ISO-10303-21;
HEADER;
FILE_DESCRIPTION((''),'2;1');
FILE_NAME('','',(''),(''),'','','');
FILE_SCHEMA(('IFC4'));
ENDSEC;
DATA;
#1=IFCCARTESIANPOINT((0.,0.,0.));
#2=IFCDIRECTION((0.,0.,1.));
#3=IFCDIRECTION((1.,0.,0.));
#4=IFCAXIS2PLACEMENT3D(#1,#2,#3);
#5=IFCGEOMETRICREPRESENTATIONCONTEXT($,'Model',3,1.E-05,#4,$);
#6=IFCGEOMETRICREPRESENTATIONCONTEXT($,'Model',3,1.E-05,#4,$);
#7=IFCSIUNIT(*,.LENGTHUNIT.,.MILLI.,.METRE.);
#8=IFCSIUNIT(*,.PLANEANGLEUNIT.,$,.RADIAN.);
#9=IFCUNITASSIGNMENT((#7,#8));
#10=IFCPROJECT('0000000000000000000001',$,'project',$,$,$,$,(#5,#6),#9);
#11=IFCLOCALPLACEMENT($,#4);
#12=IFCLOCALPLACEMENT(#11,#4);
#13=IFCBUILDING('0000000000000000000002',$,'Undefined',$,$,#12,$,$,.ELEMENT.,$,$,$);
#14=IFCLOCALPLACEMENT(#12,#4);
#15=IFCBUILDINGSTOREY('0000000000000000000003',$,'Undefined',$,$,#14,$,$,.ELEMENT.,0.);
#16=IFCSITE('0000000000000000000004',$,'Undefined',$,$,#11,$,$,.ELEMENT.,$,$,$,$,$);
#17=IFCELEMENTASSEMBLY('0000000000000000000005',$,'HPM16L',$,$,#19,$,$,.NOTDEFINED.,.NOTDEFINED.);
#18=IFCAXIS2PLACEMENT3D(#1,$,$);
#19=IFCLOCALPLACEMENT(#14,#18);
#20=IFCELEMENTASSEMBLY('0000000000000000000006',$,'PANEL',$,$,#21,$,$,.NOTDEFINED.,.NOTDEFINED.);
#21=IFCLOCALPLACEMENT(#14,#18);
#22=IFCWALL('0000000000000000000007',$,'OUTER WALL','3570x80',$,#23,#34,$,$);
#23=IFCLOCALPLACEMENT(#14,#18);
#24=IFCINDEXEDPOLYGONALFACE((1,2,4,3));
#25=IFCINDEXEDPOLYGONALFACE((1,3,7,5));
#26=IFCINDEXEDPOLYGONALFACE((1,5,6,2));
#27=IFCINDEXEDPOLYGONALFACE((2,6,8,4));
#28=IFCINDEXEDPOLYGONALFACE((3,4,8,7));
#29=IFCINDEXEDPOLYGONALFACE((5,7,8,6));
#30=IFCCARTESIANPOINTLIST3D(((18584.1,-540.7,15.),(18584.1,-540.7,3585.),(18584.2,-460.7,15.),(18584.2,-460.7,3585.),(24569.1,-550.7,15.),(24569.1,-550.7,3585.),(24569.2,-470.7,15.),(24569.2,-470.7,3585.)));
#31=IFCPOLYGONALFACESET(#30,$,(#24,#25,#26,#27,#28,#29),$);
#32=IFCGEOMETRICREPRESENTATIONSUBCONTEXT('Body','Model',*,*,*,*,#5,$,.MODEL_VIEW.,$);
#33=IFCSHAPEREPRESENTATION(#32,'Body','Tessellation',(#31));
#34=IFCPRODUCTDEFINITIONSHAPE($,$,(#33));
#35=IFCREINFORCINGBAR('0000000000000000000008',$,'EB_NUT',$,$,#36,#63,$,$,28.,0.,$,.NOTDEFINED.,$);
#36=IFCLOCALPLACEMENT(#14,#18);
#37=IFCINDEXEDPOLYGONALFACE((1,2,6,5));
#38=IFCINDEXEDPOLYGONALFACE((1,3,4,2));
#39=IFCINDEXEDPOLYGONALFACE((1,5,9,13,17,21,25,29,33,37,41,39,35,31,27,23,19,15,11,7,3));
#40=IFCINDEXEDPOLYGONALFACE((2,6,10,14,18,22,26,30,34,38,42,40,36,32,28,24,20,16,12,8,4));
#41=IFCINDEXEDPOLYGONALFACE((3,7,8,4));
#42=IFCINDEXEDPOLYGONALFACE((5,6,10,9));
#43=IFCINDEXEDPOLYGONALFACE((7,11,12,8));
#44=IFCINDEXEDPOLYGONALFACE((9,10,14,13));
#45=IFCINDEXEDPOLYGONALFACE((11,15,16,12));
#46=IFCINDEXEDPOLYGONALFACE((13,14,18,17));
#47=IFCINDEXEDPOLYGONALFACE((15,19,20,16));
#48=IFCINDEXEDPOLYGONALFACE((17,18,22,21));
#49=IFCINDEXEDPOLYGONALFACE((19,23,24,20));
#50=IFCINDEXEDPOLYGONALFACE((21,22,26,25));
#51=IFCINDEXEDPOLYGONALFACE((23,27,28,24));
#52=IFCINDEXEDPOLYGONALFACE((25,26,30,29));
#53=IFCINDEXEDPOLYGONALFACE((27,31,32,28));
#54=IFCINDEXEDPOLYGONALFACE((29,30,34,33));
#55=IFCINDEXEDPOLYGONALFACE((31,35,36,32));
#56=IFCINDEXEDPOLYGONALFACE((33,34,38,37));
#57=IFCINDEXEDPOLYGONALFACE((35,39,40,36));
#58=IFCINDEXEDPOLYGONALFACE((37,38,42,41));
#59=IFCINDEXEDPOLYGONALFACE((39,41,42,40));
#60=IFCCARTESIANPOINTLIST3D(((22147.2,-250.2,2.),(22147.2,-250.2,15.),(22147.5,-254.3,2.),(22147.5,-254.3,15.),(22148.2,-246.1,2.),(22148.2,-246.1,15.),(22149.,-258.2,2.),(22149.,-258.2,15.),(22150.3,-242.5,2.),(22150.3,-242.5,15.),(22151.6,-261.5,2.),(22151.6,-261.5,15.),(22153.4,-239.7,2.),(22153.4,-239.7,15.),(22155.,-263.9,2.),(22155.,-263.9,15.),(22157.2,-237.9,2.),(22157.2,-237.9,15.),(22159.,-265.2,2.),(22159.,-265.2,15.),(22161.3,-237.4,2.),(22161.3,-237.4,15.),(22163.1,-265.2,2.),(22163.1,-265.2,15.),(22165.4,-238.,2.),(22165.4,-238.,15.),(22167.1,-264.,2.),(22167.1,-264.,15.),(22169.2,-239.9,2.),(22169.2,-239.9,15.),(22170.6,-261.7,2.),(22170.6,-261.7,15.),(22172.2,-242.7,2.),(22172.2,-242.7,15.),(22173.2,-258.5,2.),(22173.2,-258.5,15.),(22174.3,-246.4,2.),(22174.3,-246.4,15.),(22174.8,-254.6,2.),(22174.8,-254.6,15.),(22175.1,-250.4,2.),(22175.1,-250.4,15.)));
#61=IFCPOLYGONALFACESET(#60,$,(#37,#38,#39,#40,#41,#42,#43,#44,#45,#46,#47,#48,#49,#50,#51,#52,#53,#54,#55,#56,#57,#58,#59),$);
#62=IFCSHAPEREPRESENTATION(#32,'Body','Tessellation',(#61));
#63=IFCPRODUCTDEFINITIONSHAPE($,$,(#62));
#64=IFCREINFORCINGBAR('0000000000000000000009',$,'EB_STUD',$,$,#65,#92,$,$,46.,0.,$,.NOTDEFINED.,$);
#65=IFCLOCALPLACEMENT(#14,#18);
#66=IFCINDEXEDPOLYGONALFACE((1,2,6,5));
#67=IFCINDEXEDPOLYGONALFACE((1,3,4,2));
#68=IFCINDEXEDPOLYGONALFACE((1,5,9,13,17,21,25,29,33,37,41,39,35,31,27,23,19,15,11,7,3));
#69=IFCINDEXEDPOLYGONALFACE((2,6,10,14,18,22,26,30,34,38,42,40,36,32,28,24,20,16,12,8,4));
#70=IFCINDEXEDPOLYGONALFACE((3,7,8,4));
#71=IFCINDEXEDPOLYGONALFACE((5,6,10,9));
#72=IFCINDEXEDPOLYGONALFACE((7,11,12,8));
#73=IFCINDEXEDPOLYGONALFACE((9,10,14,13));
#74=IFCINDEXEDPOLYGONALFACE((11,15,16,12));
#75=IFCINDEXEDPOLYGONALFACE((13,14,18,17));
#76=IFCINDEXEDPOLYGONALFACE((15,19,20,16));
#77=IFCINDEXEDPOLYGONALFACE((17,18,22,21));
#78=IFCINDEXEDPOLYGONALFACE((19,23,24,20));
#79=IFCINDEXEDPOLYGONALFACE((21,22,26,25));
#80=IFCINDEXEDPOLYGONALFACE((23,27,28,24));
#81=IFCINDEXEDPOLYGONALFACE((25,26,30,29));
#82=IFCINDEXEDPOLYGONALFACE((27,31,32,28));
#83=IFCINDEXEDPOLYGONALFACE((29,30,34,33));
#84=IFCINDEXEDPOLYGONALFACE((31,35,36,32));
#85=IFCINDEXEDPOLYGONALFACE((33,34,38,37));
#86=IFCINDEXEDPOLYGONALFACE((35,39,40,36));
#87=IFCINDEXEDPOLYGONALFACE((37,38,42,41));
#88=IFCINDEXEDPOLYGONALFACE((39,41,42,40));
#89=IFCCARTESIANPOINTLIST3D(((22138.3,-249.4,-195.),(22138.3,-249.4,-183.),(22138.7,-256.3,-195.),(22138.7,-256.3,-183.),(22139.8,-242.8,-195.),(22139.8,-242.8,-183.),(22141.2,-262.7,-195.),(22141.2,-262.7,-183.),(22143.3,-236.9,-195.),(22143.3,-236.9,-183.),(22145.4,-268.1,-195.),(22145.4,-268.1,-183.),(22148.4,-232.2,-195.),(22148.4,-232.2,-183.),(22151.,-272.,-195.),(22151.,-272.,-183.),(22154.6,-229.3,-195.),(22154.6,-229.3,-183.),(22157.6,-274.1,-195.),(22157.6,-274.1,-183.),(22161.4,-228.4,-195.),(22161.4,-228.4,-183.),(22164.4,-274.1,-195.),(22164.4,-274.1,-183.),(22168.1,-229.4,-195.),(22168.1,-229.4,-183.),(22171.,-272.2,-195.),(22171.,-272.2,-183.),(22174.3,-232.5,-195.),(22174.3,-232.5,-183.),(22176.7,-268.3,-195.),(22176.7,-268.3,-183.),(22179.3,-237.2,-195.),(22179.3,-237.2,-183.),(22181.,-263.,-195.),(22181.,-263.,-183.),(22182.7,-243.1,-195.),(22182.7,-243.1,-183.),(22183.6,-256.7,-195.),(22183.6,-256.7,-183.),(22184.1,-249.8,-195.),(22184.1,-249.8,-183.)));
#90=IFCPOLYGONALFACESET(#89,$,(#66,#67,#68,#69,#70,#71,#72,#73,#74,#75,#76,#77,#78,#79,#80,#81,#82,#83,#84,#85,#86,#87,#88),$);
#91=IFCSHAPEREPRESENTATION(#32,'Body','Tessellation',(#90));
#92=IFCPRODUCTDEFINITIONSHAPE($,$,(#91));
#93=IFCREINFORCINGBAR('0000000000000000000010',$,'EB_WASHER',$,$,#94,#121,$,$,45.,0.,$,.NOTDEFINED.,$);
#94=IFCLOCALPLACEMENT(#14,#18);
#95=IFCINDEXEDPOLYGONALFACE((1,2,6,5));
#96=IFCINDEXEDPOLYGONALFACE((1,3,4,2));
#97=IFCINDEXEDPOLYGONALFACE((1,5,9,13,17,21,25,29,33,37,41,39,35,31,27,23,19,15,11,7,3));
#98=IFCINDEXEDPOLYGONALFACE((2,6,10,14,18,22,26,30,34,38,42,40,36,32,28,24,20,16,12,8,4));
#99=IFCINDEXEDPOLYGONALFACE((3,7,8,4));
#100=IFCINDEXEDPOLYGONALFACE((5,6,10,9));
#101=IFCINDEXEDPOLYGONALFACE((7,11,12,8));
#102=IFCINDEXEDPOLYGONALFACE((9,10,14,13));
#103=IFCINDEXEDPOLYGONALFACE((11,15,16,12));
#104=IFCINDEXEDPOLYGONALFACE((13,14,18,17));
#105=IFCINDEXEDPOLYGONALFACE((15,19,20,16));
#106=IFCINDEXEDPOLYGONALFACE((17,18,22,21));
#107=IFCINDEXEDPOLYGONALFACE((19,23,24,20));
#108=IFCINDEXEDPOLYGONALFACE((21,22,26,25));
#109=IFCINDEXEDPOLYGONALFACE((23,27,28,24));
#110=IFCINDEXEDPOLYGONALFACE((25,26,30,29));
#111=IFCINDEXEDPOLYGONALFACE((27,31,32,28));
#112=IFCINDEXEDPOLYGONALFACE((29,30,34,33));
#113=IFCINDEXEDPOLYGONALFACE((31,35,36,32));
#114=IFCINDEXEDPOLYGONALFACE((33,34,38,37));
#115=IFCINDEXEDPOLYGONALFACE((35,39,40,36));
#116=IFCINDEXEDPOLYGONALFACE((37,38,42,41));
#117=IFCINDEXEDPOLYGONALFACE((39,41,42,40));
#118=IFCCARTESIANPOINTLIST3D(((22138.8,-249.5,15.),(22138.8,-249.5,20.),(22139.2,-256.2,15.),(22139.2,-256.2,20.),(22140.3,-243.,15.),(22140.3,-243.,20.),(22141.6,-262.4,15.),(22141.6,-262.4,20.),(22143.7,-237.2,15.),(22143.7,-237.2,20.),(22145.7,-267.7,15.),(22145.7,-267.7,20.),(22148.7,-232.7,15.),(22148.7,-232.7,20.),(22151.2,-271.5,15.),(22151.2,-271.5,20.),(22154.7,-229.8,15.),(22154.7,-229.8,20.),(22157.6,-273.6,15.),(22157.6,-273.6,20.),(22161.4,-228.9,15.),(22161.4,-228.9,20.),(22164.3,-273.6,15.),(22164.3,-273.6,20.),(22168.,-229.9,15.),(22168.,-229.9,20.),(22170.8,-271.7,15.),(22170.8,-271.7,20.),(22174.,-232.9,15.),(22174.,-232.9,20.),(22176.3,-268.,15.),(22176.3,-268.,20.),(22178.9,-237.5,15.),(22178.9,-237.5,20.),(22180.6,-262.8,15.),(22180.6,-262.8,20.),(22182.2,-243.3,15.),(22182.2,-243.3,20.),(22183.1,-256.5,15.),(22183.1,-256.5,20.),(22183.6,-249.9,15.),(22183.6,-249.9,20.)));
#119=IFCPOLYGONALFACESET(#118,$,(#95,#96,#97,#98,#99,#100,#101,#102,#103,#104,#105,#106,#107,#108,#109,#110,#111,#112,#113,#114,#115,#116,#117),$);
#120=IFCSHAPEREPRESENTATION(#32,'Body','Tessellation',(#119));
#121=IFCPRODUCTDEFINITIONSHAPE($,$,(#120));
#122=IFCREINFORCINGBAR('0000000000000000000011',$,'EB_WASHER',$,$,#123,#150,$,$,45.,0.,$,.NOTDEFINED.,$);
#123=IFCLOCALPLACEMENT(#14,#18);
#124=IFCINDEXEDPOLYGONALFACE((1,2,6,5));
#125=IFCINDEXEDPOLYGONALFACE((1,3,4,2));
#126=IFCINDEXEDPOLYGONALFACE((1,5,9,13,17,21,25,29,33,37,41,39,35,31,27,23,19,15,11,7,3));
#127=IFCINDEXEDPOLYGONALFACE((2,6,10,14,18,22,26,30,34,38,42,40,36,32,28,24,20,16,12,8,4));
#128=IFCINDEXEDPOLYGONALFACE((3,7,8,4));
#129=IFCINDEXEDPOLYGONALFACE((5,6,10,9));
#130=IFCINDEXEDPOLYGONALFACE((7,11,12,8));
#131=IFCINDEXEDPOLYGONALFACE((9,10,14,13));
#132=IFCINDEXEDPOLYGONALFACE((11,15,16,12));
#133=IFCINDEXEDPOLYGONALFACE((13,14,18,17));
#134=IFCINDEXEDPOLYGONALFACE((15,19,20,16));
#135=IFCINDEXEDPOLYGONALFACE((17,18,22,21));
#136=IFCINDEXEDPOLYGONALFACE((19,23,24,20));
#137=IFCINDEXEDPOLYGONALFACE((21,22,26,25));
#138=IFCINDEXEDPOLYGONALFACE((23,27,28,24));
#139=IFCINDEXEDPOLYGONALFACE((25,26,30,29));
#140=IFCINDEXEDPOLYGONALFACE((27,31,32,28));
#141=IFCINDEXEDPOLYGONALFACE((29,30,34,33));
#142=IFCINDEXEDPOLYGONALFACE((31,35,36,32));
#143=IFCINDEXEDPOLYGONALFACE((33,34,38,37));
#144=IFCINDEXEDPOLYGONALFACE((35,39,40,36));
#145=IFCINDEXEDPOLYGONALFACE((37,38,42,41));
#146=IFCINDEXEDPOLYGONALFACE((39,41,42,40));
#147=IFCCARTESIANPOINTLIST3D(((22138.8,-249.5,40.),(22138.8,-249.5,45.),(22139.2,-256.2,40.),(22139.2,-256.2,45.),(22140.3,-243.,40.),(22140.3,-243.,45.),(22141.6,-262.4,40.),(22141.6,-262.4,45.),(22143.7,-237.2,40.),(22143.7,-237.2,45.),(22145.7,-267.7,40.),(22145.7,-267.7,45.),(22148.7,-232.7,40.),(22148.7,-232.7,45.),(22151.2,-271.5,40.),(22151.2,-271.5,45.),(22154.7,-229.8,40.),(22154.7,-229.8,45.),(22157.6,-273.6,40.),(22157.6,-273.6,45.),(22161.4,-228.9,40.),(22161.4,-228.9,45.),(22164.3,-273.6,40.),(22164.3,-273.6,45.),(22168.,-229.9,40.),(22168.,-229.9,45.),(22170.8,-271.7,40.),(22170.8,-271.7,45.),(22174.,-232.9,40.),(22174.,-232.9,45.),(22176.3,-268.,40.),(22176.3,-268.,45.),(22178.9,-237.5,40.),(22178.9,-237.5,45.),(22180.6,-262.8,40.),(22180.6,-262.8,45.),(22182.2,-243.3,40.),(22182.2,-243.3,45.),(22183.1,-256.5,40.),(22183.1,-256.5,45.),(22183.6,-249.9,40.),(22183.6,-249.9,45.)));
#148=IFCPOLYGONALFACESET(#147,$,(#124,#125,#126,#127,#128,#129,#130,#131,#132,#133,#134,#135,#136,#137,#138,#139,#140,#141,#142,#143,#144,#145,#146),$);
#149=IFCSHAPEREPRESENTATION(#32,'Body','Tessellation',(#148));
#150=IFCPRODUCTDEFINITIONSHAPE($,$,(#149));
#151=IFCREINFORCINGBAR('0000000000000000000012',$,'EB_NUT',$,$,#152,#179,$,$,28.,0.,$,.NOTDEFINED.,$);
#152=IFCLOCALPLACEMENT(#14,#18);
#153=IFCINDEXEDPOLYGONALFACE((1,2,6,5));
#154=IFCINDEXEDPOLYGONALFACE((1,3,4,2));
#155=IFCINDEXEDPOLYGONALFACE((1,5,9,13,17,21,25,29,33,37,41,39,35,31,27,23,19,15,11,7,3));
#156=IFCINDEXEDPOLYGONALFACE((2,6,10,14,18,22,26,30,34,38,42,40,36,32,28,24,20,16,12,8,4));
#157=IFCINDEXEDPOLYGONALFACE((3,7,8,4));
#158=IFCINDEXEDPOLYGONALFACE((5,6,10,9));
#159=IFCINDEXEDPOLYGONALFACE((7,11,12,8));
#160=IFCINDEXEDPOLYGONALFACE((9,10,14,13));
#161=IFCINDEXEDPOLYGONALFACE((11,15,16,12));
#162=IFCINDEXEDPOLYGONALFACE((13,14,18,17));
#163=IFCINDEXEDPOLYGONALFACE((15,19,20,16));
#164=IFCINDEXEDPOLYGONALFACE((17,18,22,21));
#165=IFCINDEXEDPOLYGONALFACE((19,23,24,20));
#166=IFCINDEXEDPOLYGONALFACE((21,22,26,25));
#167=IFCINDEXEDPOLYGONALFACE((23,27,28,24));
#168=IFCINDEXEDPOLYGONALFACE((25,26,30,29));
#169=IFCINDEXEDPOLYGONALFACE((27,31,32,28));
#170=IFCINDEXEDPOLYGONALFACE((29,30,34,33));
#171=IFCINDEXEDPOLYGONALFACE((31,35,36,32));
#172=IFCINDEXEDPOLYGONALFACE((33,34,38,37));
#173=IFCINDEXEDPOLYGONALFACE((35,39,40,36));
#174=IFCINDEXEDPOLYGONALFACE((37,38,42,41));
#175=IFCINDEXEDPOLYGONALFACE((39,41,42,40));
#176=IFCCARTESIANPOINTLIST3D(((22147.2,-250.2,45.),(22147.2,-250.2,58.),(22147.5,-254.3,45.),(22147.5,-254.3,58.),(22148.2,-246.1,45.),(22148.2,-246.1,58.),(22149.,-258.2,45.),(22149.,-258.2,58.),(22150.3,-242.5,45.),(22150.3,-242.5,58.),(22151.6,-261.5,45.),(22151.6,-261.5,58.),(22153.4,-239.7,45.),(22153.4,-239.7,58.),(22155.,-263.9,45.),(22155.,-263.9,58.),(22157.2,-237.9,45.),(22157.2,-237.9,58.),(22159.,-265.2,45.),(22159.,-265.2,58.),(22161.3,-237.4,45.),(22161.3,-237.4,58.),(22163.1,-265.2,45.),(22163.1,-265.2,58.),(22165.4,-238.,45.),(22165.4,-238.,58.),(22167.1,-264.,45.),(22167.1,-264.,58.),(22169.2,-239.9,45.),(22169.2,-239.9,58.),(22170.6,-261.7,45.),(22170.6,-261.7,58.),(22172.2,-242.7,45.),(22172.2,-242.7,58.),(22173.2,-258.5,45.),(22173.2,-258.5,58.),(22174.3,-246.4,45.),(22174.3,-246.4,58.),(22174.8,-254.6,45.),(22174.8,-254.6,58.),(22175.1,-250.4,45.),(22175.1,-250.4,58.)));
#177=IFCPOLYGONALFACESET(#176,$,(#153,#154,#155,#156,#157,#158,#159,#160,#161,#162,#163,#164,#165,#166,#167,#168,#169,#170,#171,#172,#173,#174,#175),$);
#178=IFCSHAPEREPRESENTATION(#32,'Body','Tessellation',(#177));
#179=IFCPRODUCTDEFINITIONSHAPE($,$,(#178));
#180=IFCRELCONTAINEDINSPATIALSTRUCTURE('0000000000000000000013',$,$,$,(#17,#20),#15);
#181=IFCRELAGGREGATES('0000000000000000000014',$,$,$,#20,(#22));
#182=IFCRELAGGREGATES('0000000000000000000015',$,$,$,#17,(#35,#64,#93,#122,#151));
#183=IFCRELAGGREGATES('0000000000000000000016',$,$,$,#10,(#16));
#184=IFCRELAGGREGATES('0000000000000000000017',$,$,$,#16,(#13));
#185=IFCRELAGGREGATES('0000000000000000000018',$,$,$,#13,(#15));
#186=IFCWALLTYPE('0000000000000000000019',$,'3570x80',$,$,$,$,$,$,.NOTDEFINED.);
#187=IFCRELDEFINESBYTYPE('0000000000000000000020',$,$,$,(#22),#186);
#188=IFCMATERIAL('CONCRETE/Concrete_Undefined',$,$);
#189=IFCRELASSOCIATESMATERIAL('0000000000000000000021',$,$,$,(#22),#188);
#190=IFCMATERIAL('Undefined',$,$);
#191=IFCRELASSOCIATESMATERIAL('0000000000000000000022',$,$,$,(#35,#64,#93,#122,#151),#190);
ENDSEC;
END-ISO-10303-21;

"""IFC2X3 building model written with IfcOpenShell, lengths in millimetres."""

from ifc_helpers import new_model, entity, si_unit, frame, frame_2d, origin_with_axes, place, context, subcontext, project, spatial, rectangle, extrude, source, transform, mapped, material, type_object, element, aggregate, save


model = new_model("IFC2X3")

# Units and contexts
model_context_1 = context("Model", 3, precision=1e-05, world=origin_with_axes())
model_context_2 = context("Model", 3, precision=1e-05, world=origin_with_axes())
body_context = subcontext(model_context_1, "Body", "Model", "MODEL_VIEW")
ifc_project = project(units=[si_unit("LENGTHUNIT", "METRE", prefix="MILLI"), si_unit("PLANEANGLEUNIT", "RADIAN")], contexts=[model_context_1, model_context_2])

# Site, building, storey
site_placement = place(None, origin_with_axes())
site = spatial("IfcSite", under=ifc_project, at=site_placement, Name="Undefined", CompositionType="ELEMENT")
building_placement = place(site_placement, origin_with_axes())
building = spatial("IfcBuilding", under=site, at=building_placement, Name="Undefined", CompositionType="ELEMENT")
storey_placement = place(building_placement, origin_with_axes())
storey = spatial("IfcBuildingStorey", under=building, at=storey_placement, Name="Undefined", CompositionType="ELEMENT", Elevation=0.0)

# Shared definitions
ifc_material_1 = material(Name="CONCRETE/Concrete_Undefined")

# Element assembly
assembly_1_placement = place(storey_placement, origin_with_axes())
assembly_1 = element("IfcElementAssembly", 1, at=assembly_1_placement, inside=storey, Name="HPM16L", AssemblyPlace="NOTDEFINED", PredefinedType="NOTDEFINED")

# Element assembly
assembly_2_placement = place(storey_placement, origin_with_axes())
assembly_2 = element("IfcElementAssembly", 2, at=assembly_2_placement, inside=storey, Name="PANEL", AssemblyPlace="NOTDEFINED", PredefinedType="NOTDEFINED")

# Wall
wall_type_1 = type_object("IfcWallType", Name="3570x80", PredefinedType="NOTDEFINED")
wall_1_placement = place(assembly_2_placement, frame((18584.2, -500.7, 15.0), z_axis=(0.0, 0.0, 1.0), x_axis=(0.999999, -0.001684, 0.0)))
wall_1 = element("IfcWall", 3, at=wall_1_placement, type_object=wall_type_1, material=ifc_material_1, Name="OUTER WALL", Description="3570x80", context=body_context, shape_type="SweptSolid", body=[
    extrude(rectangle(XDim=5985.0, YDim=80.0, at=frame_2d((0.0, 2992.5), x_axis=(0.0, -1.0))), frame((0.0, 0.0, 0.0), z_axis=(0.0, 0.0, 1.0), x_axis=(0.0, -1.0, 0.0)), (0.0, 0.0, 1.0), 3570.0),
])
aggregate(assembly_2, [wall_1])

# Reinforcing bars
ifc_material_2 = material(Name="Undefined")
shared_shape_1 = source(origin_with_axes(), body_context, "Body", "AdvancedSweptSolid", [
    entity("IfcSweptDiskSolid", entity("IfcTrimmedCurve", entity("IfcLine", entity("IfcCartesianPoint", [0.0, 0.0, 0.0]), entity("IfcVector", entity("IfcDirection", [1.0, 0.0, 0.0]), 1.0)), [entity("IfcParameterValue", 0.0)], [entity("IfcParameterValue", 13.0)], True, "PARAMETER"), 14.0, None, 0.0, 13.0),
])
reinforcing_bar_1_placement = place(assembly_1_placement, frame((22161.2, -251.4, 15.0), z_axis=(0.008664, 0.999962, 0.0), x_axis=(0.0, 0.0, -1.0)))
reinforcing_bar_1 = element("IfcReinforcingBar", 4, at=reinforcing_bar_1_placement, material=ifc_material_2, Name="EB_NUT", BarRole="NOTDEFINED", CrossSectionArea=0.0, NominalDiameter=28.0, context=body_context, shape_type="MappedRepresentation", body=[
    mapped(shared_shape_1, transform((0.0, 0.0, 0.0))),
])
shared_shape_2 = source(origin_with_axes(), body_context, "Body", "AdvancedSweptSolid", [
    entity("IfcSweptDiskSolid", entity("IfcTrimmedCurve", entity("IfcLine", entity("IfcCartesianPoint", [0.0, 0.0, 0.0]), entity("IfcVector", entity("IfcDirection", [1.0, 0.0, 0.0]), 1.0)), [entity("IfcParameterValue", 0.0)], [entity("IfcParameterValue", 12.0)], True, "PARAMETER"), 23.0, None, 0.0, 12.0),
])
reinforcing_bar_2_placement = place(assembly_1_placement, frame((22161.2, -251.4, -183.0), z_axis=(0.008664, 0.999962, 0.0), x_axis=(0.0, 0.0, -1.0)))
reinforcing_bar_2 = element("IfcReinforcingBar", 5, at=reinforcing_bar_2_placement, material=ifc_material_2, Name="EB_STUD", BarRole="NOTDEFINED", CrossSectionArea=0.0, NominalDiameter=46.0, context=body_context, shape_type="MappedRepresentation", body=[
    mapped(shared_shape_2, transform((0.0, 0.0, 0.0))),
])
shared_shape_3 = source(origin_with_axes(), body_context, "Body", "AdvancedSweptSolid", [
    entity("IfcSweptDiskSolid", entity("IfcTrimmedCurve", entity("IfcLine", entity("IfcCartesianPoint", [0.0, 0.0, 0.0]), entity("IfcVector", entity("IfcDirection", [1.0, 0.0, 0.0]), 1.0)), [entity("IfcParameterValue", 0.0)], [entity("IfcParameterValue", 5.0)], True, "PARAMETER"), 22.5, None, 0.0, 5.0),
])
reinforcing_bar_3_placement = place(assembly_1_placement, frame((22161.2, -251.4, 20.0), z_axis=(0.008664, 0.999962, 0.0), x_axis=(0.0, 0.0, -1.0)))
reinforcing_bar_3 = element("IfcReinforcingBar", 6, at=reinforcing_bar_3_placement, material=ifc_material_2, Name="EB_WASHER", BarRole="NOTDEFINED", CrossSectionArea=0.0, NominalDiameter=45.0, context=body_context, shape_type="MappedRepresentation", body=[
    mapped(shared_shape_3, transform((0.0, 0.0, 0.0))),
])
shared_shape_4 = source(origin_with_axes(), body_context, "Body", "AdvancedSweptSolid", [
    entity("IfcSweptDiskSolid", entity("IfcTrimmedCurve", entity("IfcLine", entity("IfcCartesianPoint", [0.0, 0.0, 0.0]), entity("IfcVector", entity("IfcDirection", [1.0, 0.0, 0.0]), 1.0)), [entity("IfcParameterValue", 0.0)], [entity("IfcParameterValue", 5.0)], True, "PARAMETER"), 22.5, None, 0.0, 5.0),
])
reinforcing_bar_4_placement = place(assembly_1_placement, frame((22161.2, -251.4, 45.0), z_axis=(0.008664, 0.999962, 0.0), x_axis=(0.0, 0.0, -1.0)))
reinforcing_bar_4 = element("IfcReinforcingBar", 7, at=reinforcing_bar_4_placement, material=ifc_material_2, Name="EB_WASHER", BarRole="NOTDEFINED", CrossSectionArea=0.0, NominalDiameter=45.0, context=body_context, shape_type="MappedRepresentation", body=[
    mapped(shared_shape_4, transform((0.0, 0.0, 0.0))),
])
shared_shape_5 = source(origin_with_axes(), body_context, "Body", "AdvancedSweptSolid", [
    entity("IfcSweptDiskSolid", entity("IfcTrimmedCurve", entity("IfcLine", entity("IfcCartesianPoint", [0.0, 0.0, 0.0]), entity("IfcVector", entity("IfcDirection", [1.0, 0.0, 0.0]), 1.0)), [entity("IfcParameterValue", 0.0)], [entity("IfcParameterValue", 13.0)], True, "PARAMETER"), 14.0, None, 0.0, 13.0),
])
reinforcing_bar_5_placement = place(assembly_1_placement, frame((22161.2, -251.4, 58.0), z_axis=(0.008664, 0.999962, 0.0), x_axis=(0.0, 0.0, -1.0)))
reinforcing_bar_5 = element("IfcReinforcingBar", 8, at=reinforcing_bar_5_placement, material=ifc_material_2, Name="EB_NUT", BarRole="NOTDEFINED", CrossSectionArea=0.0, NominalDiameter=28.0, context=body_context, shape_type="MappedRepresentation", body=[
    mapped(shared_shape_5, transform((0.0, 0.0, 0.0))),
])
aggregate(assembly_1, [reinforcing_bar_1, reinforcing_bar_2, reinforcing_bar_3, reinforcing_bar_4, reinforcing_bar_5])

save(model, "model.ifc")
